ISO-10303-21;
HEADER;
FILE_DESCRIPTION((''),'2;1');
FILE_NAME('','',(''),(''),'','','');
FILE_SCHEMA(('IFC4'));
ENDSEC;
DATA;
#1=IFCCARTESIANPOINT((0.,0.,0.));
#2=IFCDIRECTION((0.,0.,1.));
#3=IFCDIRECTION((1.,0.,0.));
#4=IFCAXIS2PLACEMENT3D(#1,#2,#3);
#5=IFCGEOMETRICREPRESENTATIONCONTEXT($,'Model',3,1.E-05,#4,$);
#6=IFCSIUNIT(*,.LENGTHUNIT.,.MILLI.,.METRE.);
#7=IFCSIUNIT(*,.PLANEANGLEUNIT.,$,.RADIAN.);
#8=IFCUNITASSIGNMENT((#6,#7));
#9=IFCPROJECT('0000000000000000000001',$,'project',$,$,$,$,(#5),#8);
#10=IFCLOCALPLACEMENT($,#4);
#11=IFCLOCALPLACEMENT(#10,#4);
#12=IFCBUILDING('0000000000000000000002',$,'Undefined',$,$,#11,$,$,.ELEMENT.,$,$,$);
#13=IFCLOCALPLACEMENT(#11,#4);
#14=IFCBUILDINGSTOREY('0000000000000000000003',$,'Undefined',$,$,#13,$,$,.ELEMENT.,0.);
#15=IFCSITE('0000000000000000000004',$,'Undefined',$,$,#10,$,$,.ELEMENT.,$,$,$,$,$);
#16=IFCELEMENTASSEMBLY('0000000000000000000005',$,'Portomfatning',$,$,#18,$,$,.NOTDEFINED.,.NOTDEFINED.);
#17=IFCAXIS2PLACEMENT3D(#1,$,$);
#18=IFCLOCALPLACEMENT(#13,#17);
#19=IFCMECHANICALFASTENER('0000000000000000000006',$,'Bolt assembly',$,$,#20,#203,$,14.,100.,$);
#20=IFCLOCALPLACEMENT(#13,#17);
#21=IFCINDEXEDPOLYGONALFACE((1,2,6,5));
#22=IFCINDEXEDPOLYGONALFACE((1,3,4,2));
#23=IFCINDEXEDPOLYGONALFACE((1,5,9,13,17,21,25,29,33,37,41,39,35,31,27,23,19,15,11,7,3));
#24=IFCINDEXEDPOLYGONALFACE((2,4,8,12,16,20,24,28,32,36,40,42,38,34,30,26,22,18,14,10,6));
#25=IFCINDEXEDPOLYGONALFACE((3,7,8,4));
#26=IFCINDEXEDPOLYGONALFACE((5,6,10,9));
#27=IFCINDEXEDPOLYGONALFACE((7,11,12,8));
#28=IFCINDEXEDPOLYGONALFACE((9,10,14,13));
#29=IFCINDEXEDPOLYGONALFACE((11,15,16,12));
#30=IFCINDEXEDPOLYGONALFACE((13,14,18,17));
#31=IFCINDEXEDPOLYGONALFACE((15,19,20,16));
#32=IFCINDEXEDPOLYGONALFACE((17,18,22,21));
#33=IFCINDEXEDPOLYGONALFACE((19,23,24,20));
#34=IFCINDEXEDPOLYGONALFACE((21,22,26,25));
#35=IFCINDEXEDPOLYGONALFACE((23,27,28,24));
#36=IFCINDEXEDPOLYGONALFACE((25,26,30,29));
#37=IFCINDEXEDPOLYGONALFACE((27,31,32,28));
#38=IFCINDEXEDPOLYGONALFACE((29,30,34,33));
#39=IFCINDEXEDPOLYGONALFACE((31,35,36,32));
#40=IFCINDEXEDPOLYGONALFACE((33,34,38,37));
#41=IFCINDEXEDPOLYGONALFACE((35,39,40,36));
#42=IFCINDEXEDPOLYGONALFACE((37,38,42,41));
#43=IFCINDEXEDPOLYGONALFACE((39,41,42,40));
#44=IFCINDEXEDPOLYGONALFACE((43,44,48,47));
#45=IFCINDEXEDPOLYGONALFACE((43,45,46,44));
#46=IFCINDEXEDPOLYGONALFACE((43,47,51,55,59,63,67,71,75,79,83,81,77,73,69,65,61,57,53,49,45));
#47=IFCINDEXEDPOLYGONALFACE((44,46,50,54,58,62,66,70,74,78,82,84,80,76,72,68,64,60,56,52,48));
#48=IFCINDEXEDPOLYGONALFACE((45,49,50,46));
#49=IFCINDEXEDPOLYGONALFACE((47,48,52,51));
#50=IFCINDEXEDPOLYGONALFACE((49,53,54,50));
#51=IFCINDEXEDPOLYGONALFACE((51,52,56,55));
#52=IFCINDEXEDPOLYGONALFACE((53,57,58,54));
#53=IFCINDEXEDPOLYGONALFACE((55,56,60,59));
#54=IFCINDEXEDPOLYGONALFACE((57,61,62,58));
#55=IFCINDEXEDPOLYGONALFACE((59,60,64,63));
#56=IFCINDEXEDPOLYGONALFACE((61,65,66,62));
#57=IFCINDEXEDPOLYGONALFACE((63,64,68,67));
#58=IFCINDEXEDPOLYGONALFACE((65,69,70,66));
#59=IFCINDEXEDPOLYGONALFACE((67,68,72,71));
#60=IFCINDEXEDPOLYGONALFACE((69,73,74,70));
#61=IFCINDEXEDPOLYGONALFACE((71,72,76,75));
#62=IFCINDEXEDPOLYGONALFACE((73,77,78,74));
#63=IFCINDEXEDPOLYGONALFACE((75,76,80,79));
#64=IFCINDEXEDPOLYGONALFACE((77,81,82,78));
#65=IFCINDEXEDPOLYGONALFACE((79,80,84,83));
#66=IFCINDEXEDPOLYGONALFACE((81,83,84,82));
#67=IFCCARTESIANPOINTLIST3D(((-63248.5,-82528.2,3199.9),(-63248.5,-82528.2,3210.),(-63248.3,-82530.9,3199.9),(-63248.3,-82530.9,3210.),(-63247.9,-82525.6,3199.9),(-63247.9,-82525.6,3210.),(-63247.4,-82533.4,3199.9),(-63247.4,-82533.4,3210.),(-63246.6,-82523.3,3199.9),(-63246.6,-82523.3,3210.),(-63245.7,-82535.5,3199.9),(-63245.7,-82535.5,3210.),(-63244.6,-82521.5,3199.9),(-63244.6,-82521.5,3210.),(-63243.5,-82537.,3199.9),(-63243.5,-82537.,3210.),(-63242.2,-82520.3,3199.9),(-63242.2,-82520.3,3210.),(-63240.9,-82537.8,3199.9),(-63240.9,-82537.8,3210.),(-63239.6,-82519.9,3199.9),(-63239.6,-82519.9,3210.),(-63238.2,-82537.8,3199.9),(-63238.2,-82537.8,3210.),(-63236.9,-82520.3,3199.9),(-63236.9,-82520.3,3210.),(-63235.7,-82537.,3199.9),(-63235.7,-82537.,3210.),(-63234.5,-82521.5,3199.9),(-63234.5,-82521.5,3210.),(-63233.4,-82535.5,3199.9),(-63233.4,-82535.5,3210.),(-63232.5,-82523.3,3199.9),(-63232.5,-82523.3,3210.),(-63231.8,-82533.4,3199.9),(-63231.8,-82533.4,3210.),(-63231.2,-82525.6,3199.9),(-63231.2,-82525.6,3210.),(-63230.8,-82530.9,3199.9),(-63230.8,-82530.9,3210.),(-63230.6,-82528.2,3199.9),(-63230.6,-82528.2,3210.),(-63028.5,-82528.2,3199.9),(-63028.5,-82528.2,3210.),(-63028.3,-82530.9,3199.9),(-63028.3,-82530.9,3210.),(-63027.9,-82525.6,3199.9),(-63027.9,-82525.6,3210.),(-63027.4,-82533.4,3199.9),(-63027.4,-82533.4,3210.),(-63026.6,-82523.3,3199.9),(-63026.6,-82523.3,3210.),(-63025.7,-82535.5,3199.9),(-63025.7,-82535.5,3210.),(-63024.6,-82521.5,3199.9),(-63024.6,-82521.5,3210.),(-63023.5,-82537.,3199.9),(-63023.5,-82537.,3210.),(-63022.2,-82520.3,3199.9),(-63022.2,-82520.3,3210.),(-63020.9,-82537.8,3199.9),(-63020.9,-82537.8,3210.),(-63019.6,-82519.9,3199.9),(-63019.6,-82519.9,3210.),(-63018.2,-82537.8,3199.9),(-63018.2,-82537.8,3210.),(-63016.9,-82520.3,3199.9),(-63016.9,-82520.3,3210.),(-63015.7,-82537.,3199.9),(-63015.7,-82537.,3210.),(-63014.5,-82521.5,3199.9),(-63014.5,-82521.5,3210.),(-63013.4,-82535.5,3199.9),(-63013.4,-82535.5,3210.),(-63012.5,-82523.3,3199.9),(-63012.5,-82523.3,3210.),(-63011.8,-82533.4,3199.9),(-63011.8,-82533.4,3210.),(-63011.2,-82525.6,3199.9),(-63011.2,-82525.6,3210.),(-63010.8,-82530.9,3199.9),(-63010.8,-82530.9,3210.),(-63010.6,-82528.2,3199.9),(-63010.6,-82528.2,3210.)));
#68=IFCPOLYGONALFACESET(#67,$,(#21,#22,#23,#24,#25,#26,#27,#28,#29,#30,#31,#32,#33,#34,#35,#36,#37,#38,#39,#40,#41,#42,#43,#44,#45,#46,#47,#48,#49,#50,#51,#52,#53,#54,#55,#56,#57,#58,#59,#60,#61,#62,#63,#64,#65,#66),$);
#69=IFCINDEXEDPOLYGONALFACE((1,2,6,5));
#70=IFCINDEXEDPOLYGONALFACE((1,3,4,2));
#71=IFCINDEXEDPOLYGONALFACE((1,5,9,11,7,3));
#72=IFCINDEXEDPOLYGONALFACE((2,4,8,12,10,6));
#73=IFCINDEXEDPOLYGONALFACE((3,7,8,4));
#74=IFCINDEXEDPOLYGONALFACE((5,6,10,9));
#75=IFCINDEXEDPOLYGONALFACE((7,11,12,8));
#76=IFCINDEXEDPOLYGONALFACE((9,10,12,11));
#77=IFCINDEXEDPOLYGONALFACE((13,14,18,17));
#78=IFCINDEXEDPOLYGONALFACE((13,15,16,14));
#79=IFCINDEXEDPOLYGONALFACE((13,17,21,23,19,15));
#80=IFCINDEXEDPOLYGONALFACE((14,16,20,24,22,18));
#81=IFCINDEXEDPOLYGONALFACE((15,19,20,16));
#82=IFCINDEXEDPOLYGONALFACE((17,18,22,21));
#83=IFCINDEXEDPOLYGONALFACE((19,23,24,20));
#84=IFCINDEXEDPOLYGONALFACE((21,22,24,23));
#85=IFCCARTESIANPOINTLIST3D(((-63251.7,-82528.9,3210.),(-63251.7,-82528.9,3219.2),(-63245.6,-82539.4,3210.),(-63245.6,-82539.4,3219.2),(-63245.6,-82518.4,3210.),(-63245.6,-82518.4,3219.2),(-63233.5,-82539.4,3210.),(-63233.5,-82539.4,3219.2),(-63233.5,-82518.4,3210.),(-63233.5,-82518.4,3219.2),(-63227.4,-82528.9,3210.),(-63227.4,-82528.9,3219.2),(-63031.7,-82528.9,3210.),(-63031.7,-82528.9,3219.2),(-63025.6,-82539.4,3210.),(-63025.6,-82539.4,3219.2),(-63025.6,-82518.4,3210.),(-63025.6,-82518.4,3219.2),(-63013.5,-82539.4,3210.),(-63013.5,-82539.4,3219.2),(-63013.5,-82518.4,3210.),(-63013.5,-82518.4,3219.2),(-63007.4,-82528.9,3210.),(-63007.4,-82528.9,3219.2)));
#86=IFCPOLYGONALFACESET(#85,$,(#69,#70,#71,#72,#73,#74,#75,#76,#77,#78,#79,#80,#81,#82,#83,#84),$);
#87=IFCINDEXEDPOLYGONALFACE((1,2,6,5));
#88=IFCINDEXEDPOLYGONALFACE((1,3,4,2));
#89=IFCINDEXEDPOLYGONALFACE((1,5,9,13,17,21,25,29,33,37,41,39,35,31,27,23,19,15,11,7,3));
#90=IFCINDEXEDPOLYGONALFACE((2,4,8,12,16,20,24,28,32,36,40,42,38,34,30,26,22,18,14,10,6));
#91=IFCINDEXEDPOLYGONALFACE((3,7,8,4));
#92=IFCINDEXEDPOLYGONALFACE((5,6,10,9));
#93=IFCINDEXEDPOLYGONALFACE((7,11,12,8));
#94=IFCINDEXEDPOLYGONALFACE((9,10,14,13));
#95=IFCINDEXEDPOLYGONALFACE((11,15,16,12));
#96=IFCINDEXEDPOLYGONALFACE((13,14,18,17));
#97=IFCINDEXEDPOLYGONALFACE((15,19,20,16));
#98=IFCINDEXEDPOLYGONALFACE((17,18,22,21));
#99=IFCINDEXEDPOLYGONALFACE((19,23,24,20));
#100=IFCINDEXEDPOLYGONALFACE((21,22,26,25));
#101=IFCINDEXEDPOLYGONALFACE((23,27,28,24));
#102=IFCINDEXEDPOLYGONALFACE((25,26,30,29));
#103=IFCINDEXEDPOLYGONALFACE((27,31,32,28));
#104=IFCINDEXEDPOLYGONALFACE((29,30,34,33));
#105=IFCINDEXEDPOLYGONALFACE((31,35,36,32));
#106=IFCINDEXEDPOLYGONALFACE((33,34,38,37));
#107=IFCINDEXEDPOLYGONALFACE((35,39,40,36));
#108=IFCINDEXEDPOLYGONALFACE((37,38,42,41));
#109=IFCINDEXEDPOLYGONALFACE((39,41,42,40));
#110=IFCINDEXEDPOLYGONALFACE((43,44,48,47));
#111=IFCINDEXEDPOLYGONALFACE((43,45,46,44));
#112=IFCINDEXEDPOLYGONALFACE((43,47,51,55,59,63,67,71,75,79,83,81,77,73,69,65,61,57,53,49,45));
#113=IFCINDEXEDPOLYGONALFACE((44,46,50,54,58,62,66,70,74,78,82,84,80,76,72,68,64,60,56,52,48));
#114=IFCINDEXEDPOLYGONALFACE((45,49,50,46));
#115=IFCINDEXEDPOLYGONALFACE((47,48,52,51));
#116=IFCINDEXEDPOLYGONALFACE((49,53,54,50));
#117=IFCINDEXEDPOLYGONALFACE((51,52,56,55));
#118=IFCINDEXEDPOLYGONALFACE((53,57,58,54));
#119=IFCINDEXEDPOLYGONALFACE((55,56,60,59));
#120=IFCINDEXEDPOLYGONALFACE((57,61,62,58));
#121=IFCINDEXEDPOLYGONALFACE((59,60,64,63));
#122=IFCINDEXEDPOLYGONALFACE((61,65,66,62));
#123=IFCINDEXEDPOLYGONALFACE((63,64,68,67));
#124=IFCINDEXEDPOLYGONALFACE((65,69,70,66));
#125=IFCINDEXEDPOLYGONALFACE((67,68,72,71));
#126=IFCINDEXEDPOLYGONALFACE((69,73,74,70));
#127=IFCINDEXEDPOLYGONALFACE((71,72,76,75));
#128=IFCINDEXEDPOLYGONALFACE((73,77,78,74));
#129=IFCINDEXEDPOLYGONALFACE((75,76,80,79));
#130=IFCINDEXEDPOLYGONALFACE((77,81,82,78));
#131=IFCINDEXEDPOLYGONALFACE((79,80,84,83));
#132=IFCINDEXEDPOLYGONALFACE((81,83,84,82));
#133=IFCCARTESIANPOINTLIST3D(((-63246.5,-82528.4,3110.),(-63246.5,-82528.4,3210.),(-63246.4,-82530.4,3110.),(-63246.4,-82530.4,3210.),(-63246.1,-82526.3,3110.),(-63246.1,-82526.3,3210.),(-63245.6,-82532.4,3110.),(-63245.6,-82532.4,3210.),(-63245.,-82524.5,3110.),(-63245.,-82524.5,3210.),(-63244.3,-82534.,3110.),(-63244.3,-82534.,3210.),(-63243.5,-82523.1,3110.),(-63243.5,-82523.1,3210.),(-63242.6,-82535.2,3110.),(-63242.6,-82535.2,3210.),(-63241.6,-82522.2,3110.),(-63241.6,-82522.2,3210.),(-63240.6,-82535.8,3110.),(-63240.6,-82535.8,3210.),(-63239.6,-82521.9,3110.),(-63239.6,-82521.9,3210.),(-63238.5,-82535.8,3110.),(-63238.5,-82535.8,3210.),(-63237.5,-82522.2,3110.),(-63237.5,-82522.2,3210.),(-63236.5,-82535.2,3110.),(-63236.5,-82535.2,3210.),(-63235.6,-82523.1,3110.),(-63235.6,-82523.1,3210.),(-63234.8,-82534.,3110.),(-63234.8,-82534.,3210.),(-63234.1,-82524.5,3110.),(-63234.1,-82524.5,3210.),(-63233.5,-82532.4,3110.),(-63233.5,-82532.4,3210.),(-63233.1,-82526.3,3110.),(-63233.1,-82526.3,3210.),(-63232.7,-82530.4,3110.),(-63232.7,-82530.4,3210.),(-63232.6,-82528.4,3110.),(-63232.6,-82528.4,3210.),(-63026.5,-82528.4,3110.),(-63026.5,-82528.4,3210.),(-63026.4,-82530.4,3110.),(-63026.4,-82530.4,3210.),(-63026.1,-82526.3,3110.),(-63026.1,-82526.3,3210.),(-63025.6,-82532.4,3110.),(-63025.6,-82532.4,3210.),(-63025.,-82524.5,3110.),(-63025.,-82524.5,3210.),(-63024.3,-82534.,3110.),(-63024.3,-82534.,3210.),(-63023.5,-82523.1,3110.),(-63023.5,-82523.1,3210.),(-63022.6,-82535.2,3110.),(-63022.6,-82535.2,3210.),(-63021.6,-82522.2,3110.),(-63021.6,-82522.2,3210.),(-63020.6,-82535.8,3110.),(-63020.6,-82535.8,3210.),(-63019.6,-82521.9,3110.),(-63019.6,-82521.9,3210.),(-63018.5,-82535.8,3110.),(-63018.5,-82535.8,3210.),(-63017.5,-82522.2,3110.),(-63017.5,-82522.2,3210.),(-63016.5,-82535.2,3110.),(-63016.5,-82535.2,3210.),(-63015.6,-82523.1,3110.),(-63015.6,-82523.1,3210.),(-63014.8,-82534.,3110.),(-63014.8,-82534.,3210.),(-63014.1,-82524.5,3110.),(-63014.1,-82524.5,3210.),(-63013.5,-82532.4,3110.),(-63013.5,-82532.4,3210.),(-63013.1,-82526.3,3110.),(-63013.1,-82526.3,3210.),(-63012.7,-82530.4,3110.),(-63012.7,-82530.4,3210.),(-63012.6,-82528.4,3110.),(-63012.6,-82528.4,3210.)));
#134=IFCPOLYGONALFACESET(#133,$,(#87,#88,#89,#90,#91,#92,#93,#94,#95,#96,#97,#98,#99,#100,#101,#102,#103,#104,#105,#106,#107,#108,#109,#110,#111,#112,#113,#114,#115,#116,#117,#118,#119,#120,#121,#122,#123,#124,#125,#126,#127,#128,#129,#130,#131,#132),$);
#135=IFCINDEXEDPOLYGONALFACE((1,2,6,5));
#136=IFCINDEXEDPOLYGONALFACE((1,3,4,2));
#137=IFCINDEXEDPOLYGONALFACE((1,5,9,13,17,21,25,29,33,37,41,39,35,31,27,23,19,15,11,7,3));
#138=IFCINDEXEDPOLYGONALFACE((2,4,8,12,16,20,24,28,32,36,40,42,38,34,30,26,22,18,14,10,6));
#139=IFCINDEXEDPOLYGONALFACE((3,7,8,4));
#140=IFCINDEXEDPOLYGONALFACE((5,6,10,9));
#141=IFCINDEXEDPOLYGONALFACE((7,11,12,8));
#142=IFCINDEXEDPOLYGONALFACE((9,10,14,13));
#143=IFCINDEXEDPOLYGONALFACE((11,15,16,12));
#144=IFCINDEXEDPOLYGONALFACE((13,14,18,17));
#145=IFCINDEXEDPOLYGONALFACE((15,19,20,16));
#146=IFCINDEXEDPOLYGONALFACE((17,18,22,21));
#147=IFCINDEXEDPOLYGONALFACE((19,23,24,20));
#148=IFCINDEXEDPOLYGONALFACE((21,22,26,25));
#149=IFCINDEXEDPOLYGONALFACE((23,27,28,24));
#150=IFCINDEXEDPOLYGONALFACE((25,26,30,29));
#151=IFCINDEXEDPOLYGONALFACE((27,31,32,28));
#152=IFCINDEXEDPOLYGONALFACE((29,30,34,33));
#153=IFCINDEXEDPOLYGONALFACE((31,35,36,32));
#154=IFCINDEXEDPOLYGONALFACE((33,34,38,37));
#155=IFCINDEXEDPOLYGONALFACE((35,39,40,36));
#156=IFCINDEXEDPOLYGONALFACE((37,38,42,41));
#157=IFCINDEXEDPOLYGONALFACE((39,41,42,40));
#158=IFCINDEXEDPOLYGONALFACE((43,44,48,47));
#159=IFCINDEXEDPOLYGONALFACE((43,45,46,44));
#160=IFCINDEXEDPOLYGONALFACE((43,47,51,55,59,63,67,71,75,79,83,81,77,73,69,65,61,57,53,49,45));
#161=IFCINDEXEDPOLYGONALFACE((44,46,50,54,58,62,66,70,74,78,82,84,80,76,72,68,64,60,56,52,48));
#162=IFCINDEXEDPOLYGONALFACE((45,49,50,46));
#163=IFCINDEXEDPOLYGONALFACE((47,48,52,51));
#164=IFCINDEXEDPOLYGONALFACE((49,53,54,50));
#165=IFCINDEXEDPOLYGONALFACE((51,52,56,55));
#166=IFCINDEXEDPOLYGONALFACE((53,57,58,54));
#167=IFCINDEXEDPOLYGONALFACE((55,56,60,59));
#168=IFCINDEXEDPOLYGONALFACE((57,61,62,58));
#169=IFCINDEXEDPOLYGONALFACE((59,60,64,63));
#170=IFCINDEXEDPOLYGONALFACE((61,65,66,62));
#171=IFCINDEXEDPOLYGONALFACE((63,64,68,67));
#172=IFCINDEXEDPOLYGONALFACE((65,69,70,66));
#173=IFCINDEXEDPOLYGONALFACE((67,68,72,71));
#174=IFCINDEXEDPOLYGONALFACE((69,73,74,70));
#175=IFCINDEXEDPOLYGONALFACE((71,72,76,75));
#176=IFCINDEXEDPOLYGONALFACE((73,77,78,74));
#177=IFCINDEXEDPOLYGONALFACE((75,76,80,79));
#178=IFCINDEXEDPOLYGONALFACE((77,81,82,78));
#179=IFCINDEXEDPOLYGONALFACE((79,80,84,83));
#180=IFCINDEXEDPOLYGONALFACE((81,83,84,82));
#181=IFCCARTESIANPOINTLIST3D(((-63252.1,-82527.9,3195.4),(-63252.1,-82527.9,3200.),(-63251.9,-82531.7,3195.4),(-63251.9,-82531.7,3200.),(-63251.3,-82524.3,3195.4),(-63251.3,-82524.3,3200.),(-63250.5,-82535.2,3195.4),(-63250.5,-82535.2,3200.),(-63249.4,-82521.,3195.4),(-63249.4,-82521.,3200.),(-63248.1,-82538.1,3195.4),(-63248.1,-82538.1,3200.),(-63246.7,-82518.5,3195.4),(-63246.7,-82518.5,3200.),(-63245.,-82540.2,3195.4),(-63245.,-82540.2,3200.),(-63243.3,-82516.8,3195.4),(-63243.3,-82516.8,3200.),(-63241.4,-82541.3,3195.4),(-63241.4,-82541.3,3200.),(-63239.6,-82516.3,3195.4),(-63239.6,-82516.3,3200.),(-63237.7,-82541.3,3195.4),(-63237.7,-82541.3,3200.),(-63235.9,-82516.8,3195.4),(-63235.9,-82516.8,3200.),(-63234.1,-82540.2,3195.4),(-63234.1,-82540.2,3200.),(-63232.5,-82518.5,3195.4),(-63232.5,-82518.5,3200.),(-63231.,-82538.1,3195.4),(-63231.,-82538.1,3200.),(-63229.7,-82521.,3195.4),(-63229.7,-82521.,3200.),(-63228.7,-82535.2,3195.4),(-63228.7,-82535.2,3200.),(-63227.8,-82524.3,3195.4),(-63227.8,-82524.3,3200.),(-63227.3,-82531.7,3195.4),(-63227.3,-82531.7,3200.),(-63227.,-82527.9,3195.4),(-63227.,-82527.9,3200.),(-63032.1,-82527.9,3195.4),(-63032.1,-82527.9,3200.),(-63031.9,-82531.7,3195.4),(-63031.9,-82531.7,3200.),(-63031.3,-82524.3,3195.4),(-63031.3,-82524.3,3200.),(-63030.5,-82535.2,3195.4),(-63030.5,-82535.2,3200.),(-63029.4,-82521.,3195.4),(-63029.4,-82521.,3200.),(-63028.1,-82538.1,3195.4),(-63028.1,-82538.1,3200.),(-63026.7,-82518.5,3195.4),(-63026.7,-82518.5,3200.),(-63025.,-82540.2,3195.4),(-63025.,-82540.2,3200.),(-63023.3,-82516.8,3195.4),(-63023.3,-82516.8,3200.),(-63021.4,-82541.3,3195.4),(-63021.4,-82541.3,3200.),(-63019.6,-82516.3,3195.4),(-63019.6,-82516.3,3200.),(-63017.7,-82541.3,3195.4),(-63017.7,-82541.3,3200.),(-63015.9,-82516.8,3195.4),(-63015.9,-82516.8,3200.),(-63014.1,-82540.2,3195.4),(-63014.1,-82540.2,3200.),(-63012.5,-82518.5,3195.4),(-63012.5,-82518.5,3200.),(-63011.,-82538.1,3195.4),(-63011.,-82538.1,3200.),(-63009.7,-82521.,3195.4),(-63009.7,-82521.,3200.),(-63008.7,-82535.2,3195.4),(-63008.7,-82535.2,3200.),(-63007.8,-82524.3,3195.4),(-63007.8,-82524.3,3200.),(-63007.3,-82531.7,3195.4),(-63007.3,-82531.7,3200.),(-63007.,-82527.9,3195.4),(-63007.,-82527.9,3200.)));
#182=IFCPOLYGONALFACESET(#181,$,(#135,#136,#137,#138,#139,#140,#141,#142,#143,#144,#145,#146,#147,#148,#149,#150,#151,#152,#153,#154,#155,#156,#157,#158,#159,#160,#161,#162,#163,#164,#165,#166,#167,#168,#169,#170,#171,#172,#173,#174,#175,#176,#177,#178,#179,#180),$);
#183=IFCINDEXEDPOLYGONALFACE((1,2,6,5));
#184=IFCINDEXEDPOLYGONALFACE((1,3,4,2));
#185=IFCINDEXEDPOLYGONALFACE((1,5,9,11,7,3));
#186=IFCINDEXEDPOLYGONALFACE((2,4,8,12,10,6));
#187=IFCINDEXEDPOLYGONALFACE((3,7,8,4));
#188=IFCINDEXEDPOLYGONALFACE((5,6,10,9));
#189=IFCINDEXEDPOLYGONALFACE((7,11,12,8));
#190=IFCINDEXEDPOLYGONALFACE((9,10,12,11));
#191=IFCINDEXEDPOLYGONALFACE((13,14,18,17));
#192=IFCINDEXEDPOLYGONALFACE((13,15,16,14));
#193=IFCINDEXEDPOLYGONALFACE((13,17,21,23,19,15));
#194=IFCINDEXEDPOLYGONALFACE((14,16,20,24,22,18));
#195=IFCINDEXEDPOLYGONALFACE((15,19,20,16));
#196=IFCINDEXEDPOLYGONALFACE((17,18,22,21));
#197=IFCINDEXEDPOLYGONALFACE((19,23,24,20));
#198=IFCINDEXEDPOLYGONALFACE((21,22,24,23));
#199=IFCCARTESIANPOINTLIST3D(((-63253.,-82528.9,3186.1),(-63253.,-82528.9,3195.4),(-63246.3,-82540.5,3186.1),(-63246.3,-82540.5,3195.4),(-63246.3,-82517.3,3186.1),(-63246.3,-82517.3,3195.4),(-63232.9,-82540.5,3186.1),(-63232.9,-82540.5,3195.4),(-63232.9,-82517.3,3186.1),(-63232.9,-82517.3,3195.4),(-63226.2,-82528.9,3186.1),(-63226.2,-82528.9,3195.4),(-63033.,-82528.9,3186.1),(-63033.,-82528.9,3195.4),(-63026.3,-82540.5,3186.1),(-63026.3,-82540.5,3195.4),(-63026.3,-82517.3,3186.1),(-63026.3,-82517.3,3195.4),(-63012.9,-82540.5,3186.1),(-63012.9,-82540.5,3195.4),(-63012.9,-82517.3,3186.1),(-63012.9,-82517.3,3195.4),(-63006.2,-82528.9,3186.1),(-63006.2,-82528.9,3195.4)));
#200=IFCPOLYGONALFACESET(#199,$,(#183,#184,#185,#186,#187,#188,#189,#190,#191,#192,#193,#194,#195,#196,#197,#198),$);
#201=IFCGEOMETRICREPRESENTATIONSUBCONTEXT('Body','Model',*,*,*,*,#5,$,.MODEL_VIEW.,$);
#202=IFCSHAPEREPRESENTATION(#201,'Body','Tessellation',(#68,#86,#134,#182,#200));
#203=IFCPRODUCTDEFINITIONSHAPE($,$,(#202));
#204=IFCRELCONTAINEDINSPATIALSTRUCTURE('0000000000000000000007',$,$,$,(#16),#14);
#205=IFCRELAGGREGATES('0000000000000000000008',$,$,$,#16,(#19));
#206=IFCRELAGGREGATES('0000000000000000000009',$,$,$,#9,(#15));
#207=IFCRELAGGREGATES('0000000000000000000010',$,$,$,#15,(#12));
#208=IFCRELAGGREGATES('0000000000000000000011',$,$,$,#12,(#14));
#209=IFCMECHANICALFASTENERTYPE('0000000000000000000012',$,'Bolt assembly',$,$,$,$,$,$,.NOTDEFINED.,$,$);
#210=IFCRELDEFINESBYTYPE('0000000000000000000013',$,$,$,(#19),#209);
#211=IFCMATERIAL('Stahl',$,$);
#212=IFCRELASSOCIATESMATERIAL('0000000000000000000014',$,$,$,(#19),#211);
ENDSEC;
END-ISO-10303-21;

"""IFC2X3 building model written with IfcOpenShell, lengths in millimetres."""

from ifc_helpers import new_model, si_unit, frame, origin_with_axes, origin_2d_with_axis, place, context, subcontext, project, spatial, polyline, circle, outline, extrude, source, transform, mapped, material, type_object, element, aggregate, save


model = new_model("IFC2X3")

# Units and contexts
model_context = context("Model", 3, precision=1e-05, world=origin_with_axes())
body_context = subcontext(model_context, "Body", "Model", "MODEL_VIEW")
ifc_project = project(units=[si_unit("LENGTHUNIT", "METRE", prefix="MILLI"), si_unit("PLANEANGLEUNIT", "RADIAN")], contexts=[model_context])

# Site, building, storey
site_placement = place(None, origin_with_axes())
site = spatial("IfcSite", under=ifc_project, at=site_placement, Name="Undefined", CompositionType="ELEMENT")
building_placement = place(site_placement, origin_with_axes())
building = spatial("IfcBuilding", under=site, at=building_placement, Name="Undefined", CompositionType="ELEMENT")
storey_placement = place(building_placement, origin_with_axes())
storey = spatial("IfcBuildingStorey", under=building, at=storey_placement, Name="Undefined", CompositionType="ELEMENT", Elevation=0.0)

# Element assembly
assembly_1_placement = place(storey_placement, origin_with_axes())
assembly_1 = element("IfcElementAssembly", 1, at=assembly_1_placement, inside=storey, Name="Portomfatning", AssemblyPlace="NOTDEFINED", PredefinedType="NOTDEFINED")

# Mechanical fastener
mechanical_fastener_type = type_object("IfcMechanicalFastenerType", Name="Bolt assembly")
ifc_material_1 = material(Name="Stahl")
shared_shape_1 = source(origin_with_axes(), body_context, "Body", "SweptSolid", [
    extrude(circle(Radius=9.0, at=origin_2d_with_axis()), frame((0.0, 0.0, 0.0), z_axis=(0.0, 1.0, 0.0), x_axis=(1.0, 0.0, 0.0)), (0.0, 0.0, 1.0), 10.1),
    extrude(outline(polyline([(10.5, -6.1), (10.5, 6.1), (0.0, 12.1), (-10.5, 6.1), (-10.5, -6.1), (0.0, -12.1), (10.5, -6.1)])), frame((0.0, -9.2, 0.0), z_axis=(0.0, 1.0, 0.0), x_axis=(1.0, 0.0, 0.0)), (0.0, 0.0, 1.0), 9.2),
    extrude(circle(Radius=7.0, at=origin_2d_with_axis()), frame((0.0, 0.0, 0.0), z_axis=(0.0, 1.0, 0.0), x_axis=(1.0, 0.0, 0.0)), (0.0, 0.0, 1.0), 100.0),
    extrude(circle(Radius=12.6, at=origin_2d_with_axis()), frame((0.0, 10.0, 0.0), z_axis=(0.0, 1.0, 0.0), x_axis=(1.0, 0.0, 0.0)), (0.0, 0.0, 1.0), 4.6),
    extrude(outline(polyline([(11.6, -6.7), (11.6, 6.7), (0.0, 13.4), (-11.6, 6.7), (-11.6, -6.7), (0.0, -13.4), (11.6, -6.7)])), frame((0.0, 14.6, 0.0), z_axis=(0.0, 1.0, 0.0), x_axis=(1.0, 0.0, 0.0)), (0.0, 0.0, 1.0), 9.2),
])
mechanical_fastener_1_placement = place(assembly_1_placement, frame((-63129.6, -82528.9, 3210.0), z_axis=(-1.0, 0.0, 0.0), x_axis=(0.0, 1.0, 0.0)))
mechanical_fastener_1 = element("IfcMechanicalFastener", 2, at=mechanical_fastener_1_placement, type_object=mechanical_fastener_type, material=ifc_material_1, Name="Bolt assembly", NominalDiameter=14.0, NominalLength=100.0, context=body_context, shape_type="MappedRepresentation", body=[
    mapped(shared_shape_1, transform((0.0, 0.0, -110.0))),
    mapped(shared_shape_1, transform((0.0, 0.0, 110.0))),
])

aggregate(assembly_1, [mechanical_fastener_1])

save(model, "model.ifc")
